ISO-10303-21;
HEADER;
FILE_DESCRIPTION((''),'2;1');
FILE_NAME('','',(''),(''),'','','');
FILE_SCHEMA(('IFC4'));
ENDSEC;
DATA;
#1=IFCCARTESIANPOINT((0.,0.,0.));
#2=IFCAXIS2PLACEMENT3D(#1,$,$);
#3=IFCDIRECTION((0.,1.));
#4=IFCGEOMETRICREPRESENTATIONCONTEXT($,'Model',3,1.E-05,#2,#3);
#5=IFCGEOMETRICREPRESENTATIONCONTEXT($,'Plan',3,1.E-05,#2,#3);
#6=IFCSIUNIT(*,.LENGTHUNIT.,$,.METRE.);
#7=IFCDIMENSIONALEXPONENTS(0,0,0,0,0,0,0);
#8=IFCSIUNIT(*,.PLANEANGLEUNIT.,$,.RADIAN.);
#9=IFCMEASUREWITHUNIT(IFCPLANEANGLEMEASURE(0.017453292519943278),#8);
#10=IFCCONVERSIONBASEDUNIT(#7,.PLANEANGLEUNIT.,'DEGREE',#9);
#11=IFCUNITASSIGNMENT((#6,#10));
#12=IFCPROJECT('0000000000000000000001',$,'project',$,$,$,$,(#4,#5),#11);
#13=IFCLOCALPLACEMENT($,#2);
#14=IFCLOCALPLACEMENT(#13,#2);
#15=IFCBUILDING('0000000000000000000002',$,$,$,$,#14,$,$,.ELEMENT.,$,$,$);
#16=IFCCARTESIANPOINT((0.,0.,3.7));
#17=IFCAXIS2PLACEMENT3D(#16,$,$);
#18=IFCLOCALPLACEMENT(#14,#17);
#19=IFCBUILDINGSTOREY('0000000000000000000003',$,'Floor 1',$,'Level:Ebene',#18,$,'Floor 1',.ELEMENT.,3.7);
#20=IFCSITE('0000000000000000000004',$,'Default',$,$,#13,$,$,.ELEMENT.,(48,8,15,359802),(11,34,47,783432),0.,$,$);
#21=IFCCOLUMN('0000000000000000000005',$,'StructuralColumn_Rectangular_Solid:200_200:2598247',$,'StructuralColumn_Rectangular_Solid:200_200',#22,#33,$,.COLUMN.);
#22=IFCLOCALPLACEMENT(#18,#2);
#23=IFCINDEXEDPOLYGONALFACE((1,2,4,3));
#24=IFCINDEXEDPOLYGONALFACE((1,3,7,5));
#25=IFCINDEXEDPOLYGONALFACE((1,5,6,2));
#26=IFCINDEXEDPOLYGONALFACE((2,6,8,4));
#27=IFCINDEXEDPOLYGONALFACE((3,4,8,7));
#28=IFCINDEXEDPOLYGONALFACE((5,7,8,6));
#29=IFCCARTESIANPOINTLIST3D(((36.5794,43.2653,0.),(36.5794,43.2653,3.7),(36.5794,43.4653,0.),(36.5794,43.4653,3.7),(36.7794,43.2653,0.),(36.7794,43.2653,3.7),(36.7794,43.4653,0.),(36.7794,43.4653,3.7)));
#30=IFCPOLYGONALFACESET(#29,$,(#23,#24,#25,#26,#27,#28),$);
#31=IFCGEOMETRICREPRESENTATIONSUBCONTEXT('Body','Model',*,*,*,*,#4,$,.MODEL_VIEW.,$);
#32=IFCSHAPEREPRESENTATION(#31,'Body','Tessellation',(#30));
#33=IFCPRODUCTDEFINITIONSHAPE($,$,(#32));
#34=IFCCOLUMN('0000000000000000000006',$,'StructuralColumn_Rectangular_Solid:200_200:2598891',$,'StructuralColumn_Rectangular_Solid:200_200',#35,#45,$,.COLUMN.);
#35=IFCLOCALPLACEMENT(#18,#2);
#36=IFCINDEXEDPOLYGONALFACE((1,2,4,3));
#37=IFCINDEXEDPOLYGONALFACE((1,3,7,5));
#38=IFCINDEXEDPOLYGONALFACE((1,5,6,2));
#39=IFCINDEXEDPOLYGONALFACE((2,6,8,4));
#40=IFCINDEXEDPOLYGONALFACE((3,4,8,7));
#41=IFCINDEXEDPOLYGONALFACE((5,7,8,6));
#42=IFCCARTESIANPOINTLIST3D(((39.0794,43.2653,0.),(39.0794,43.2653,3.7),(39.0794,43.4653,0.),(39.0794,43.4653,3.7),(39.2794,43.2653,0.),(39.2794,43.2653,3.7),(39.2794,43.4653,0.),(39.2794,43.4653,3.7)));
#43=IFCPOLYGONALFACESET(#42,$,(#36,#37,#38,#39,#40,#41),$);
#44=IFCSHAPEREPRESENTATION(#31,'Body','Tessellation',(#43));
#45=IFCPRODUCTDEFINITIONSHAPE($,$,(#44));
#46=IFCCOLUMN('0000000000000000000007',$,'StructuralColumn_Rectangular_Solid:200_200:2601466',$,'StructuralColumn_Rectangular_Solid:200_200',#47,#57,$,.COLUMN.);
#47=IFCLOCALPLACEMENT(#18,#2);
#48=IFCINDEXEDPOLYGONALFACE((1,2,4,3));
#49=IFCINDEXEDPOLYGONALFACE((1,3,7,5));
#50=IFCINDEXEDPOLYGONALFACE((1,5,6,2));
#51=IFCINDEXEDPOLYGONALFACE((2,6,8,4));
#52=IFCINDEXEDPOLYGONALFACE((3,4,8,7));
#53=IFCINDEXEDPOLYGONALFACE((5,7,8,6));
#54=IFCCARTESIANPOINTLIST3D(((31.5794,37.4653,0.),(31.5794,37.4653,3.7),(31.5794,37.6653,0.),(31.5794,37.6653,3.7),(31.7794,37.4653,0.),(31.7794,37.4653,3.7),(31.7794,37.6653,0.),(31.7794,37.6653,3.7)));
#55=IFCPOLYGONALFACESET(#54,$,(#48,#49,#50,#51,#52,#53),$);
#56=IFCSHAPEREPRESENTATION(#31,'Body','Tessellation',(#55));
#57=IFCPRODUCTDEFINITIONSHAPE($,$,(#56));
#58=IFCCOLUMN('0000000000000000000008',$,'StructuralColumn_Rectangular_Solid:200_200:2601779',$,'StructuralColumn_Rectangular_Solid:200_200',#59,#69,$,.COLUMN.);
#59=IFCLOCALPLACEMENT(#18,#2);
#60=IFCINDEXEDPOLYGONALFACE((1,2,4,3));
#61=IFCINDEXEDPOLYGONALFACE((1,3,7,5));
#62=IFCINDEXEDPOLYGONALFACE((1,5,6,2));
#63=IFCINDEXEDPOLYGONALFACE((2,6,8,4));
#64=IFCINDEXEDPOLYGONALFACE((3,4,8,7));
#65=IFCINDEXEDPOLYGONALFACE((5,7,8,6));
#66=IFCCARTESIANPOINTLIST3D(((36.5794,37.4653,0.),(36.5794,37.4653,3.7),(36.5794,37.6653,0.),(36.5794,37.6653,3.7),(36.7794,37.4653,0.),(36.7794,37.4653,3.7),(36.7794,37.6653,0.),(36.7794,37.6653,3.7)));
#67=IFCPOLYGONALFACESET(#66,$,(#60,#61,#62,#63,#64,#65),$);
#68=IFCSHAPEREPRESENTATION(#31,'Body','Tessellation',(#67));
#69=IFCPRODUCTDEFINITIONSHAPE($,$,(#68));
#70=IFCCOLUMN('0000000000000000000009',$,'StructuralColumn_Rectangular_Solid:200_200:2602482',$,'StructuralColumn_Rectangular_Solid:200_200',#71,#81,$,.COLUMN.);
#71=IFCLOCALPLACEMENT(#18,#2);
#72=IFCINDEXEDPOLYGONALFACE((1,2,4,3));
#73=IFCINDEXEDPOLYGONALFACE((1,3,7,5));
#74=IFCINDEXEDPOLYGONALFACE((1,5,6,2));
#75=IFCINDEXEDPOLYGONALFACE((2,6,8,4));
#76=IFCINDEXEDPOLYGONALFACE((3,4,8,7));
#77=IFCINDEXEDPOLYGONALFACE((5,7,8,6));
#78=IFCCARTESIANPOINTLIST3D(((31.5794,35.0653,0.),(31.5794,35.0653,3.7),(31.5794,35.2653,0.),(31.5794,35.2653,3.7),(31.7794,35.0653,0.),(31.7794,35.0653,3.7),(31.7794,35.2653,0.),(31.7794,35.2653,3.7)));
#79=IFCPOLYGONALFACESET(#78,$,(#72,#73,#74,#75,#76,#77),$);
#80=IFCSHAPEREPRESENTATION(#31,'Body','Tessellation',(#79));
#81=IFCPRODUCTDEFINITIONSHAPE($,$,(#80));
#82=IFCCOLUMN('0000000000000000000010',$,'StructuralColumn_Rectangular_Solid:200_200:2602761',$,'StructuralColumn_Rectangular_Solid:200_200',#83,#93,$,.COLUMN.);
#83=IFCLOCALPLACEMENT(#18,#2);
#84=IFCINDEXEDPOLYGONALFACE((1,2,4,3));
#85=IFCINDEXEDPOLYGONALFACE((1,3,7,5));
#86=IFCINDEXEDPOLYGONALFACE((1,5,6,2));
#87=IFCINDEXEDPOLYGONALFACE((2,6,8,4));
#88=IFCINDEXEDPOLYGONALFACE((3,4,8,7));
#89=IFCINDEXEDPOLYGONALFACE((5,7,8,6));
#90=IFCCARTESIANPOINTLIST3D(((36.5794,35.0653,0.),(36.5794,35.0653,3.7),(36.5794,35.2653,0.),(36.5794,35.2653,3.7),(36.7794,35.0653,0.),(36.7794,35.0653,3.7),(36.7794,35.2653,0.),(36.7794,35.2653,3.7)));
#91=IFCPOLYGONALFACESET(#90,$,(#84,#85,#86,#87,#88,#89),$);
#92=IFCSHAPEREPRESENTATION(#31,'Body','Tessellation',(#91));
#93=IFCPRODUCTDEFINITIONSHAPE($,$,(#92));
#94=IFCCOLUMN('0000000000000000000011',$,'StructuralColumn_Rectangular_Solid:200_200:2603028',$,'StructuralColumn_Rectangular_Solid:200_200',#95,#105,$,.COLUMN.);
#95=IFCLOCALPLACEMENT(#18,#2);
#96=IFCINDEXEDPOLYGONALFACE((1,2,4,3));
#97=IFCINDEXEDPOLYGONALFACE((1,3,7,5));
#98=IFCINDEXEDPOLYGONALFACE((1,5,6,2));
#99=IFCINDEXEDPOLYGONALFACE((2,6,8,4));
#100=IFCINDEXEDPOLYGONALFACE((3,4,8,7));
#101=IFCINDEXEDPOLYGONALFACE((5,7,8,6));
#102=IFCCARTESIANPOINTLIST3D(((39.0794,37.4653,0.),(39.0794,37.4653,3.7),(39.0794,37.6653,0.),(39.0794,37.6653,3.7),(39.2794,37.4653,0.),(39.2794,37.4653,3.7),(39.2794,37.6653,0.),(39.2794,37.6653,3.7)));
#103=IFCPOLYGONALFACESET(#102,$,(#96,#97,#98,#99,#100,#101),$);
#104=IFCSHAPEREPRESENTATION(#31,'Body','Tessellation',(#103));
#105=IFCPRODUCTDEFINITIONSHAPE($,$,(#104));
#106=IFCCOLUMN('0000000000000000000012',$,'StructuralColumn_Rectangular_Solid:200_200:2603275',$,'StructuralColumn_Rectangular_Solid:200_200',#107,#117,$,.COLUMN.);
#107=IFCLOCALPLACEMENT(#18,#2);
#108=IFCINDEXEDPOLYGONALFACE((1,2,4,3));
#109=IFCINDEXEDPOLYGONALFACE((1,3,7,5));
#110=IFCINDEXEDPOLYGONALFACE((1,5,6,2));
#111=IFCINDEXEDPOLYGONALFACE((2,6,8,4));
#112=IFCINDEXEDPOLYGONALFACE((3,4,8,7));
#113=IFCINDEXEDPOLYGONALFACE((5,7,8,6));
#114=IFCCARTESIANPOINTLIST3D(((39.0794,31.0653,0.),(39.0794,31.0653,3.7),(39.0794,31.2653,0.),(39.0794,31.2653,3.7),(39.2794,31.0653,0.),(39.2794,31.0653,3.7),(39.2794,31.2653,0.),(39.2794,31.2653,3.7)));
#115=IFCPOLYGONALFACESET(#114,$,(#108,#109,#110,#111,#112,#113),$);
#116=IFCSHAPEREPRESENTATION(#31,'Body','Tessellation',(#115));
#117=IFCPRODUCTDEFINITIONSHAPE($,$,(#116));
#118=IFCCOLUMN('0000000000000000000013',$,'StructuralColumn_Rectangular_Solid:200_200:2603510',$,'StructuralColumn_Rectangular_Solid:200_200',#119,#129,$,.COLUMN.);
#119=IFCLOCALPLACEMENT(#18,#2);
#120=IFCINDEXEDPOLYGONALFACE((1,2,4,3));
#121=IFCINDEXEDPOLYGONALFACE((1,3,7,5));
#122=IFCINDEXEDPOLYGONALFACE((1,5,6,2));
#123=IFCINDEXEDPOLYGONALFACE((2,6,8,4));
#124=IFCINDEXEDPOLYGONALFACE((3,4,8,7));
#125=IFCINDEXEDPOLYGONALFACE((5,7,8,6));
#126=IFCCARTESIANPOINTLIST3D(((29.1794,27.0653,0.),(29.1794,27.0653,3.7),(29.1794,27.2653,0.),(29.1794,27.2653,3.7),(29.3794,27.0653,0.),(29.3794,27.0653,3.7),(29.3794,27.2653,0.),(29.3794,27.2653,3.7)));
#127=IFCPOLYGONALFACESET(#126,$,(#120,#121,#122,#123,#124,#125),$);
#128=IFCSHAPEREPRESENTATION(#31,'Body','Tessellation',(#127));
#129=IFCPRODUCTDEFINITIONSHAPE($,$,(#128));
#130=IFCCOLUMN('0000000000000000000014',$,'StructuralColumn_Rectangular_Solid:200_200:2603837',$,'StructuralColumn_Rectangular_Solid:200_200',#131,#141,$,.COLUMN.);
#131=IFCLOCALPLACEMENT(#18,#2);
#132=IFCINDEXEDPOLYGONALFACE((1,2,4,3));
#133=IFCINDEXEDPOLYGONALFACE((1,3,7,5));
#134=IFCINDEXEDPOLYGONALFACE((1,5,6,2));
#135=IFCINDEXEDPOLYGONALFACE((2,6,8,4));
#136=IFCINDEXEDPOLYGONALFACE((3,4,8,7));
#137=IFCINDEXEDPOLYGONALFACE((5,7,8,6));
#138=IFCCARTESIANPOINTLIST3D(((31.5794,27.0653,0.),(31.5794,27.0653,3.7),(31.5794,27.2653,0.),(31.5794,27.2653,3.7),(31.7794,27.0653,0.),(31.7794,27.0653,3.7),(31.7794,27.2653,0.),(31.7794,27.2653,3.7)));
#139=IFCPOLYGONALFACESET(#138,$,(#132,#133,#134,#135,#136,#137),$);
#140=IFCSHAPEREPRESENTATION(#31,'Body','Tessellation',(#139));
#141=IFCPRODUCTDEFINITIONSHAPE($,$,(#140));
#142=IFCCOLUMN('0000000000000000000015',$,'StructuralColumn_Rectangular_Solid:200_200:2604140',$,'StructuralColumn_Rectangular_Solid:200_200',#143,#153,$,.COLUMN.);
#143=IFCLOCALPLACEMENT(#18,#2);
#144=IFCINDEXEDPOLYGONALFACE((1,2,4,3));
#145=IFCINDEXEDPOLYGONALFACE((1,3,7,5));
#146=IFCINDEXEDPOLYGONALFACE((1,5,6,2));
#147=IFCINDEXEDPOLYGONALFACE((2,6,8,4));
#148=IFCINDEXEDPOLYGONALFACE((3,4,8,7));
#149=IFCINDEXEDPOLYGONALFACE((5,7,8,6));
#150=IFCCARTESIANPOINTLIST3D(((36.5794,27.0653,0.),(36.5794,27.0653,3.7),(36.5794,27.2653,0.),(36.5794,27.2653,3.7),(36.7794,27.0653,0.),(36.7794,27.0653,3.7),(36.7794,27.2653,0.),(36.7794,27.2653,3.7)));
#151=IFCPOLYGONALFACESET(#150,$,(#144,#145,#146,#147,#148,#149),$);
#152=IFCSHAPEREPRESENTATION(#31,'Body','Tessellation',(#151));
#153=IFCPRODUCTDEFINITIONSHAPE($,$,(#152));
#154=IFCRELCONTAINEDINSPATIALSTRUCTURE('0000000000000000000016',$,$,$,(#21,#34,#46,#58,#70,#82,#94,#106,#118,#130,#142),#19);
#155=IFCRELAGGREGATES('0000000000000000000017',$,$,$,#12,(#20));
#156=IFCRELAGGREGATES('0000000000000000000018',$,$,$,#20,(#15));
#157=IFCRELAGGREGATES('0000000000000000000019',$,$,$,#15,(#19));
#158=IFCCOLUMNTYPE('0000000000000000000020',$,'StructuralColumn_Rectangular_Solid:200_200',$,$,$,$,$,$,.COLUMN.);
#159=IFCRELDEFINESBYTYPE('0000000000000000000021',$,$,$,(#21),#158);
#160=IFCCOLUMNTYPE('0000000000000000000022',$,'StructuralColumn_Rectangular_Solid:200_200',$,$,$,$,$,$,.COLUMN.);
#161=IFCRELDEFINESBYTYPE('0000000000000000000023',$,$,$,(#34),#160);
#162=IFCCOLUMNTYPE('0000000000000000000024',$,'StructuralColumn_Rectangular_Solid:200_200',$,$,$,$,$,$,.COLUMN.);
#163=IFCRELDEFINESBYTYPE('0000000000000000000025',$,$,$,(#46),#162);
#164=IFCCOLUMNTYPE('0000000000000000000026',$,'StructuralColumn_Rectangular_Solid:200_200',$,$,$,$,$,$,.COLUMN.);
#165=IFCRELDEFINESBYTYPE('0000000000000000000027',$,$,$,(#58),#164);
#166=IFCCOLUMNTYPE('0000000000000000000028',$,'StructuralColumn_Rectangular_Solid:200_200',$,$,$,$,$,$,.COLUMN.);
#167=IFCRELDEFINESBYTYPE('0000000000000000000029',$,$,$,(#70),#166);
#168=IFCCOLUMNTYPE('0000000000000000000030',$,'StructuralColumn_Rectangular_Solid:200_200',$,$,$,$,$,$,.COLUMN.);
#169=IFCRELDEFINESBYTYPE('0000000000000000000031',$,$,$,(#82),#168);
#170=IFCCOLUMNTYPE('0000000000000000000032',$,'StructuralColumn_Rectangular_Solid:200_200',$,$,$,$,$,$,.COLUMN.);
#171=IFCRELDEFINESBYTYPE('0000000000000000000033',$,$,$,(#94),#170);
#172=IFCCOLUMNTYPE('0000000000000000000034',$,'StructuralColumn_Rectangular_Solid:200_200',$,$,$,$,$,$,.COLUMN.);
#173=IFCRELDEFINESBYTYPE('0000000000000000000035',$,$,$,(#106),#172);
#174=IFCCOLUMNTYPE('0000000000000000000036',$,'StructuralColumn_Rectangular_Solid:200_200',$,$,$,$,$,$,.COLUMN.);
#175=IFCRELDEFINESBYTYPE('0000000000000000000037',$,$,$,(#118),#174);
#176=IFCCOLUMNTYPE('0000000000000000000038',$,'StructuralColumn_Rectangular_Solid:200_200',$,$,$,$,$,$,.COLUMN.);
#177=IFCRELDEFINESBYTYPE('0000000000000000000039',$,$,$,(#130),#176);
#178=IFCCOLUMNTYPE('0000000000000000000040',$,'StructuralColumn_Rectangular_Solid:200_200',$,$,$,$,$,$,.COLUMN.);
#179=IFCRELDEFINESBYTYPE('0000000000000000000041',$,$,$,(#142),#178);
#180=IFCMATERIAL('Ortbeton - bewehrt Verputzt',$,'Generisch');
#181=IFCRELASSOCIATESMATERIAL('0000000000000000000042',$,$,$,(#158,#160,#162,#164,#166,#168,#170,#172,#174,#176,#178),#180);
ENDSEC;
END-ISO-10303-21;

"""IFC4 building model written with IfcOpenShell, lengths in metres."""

from ifc_helpers import new_model, entity, si_unit, converted_unit, direction, frame, frame_2d, origin, origin_2d_with_axis, place, context, subcontext, project, spatial, rectangle, extrude, source, transform, mapped, material, material_profile, profile_set, type_object, type_shapes, element, save


model = new_model("IFC4")

# Units and contexts
model_context = context("Model", 3, precision=1e-05, world=origin(), true_north=direction((0.0, 1.0)))
plan_context = context("Plan", 3, precision=1e-05, world=origin(), true_north=direction((0.0, 1.0)))
body_context = subcontext(model_context, "Body", "Model", "MODEL_VIEW")
ifc_project = project(units=[si_unit("LENGTHUNIT", "METRE"), converted_unit("PLANEANGLEUNIT", "DEGREE", entity("IfcPlaneAngleMeasure", 0.017453292519943278), si_unit("PLANEANGLEUNIT", "RADIAN"), dimensions=[0, 0, 0, 0, 0, 0, 0])], contexts=[model_context, plan_context])

# Site, building, storey
site_placement = place(None, origin())
site = spatial("IfcSite", under=ifc_project, at=site_placement, Name="Default", CompositionType="ELEMENT", RefLatitude=(48, 8, 15, 359802), RefLongitude=(11, 34, 47, 783432), RefElevation=0.0)
building_placement = place(site_placement, origin())
building = spatial("IfcBuilding", under=site, at=building_placement, CompositionType="ELEMENT")
storey_placement = place(building_placement, frame((0.0, 0.0, 3.7)))
storey = spatial("IfcBuildingStorey", under=building, at=storey_placement, Name="Floor 1", ObjectType="Level:Ebene", LongName="Floor 1", CompositionType="ELEMENT", Elevation=3.7)

# Columns
ifc_material_1 = material(Name="Ortbeton - bewehrt Verputzt", Category="Generisch")
ifc_material_profile = material_profile(ifc_material_1, rectangle(XDim=0.2, YDim=0.2, at=frame_2d((0.0, 0.0), x_axis=(1.0, 0.0))), Name="200_200")
ifc_profile_set = profile_set([ifc_material_profile], Name="200_200")
column_type_1 = type_object("IfcColumnType", Name="StructuralColumn_Rectangular_Solid:200_200", PredefinedType="COLUMN", material=ifc_profile_set)
shared_shape_1 = source(origin(), body_context, "Body", "SweptSolid", [
    extrude(rectangle(XDim=0.2, YDim=0.2, at=frame_2d((0.0, 0.0), x_axis=(1.0, 0.0))), frame((36.6794, 43.3653, 3.7), z_axis=(0.0, 0.0, 1.0), x_axis=(-1.0, 0.0, 0.0)), (0.0, 0.0, 1.0), 3.7),
])
type_shapes(column_type_1, [shared_shape_1])
column_1_placement = place(storey_placement, frame((0.0, 0.0, -3.7)))
element("IfcColumn", 1, at=column_1_placement, inside=storey, type_object=column_type_1, Name="StructuralColumn_Rectangular_Solid:200_200:2598247", ObjectType="StructuralColumn_Rectangular_Solid:200_200", PredefinedType="COLUMN", context=body_context, shape_type="MappedRepresentation", body=[
    mapped(shared_shape_1, transform((0.0, 0.0, 0.0), scale=1.0)),
])
column_type_2 = type_object("IfcColumnType", Name="StructuralColumn_Rectangular_Solid:200_200", PredefinedType="COLUMN", material=ifc_profile_set)
shared_shape_2 = source(origin(), body_context, "Body", "SweptSolid", [
    extrude(rectangle(XDim=0.2, YDim=0.2, at=frame_2d((0.0, 0.0), x_axis=(1.0, 0.0))), frame((39.1794, 43.3653, 3.7), z_axis=(0.0, 0.0, 1.0), x_axis=(-1.0, 0.0, 0.0)), (0.0, 0.0, 1.0), 3.7),
])
type_shapes(column_type_2, [shared_shape_2])
column_2_placement = place(storey_placement, frame((0.0, 0.0, -3.7)))
element("IfcColumn", 2, at=column_2_placement, inside=storey, type_object=column_type_2, Name="StructuralColumn_Rectangular_Solid:200_200:2598891", ObjectType="StructuralColumn_Rectangular_Solid:200_200", PredefinedType="COLUMN", context=body_context, shape_type="MappedRepresentation", body=[
    mapped(shared_shape_2, transform((0.0, 0.0, 0.0), scale=1.0)),
])
column_type_3 = type_object("IfcColumnType", Name="StructuralColumn_Rectangular_Solid:200_200", PredefinedType="COLUMN", material=ifc_profile_set)
shared_shape_3 = source(origin(), body_context, "Body", "SweptSolid", [
    extrude(rectangle(XDim=0.2, YDim=0.2, at=frame_2d((0.0, 0.0), x_axis=(1.0, 0.0))), frame((31.6794, 37.5653, 3.7), z_axis=(0.0, 0.0, 1.0), x_axis=(-1.0, 0.0, 0.0)), (0.0, 0.0, 1.0), 3.7),
])
type_shapes(column_type_3, [shared_shape_3])
column_3_placement = place(storey_placement, frame((0.0, 0.0, -3.7)))
element("IfcColumn", 3, at=column_3_placement, inside=storey, type_object=column_type_3, Name="StructuralColumn_Rectangular_Solid:200_200:2601466", ObjectType="StructuralColumn_Rectangular_Solid:200_200", PredefinedType="COLUMN", context=body_context, shape_type="MappedRepresentation", body=[
    mapped(shared_shape_3, transform((0.0, 0.0, 0.0), scale=1.0)),
])
column_type_4 = type_object("IfcColumnType", Name="StructuralColumn_Rectangular_Solid:200_200", PredefinedType="COLUMN", material=ifc_profile_set)
shared_shape_4 = source(origin(), body_context, "Body", "SweptSolid", [
    extrude(rectangle(XDim=0.2, YDim=0.2, at=origin_2d_with_axis()), frame((36.6794, 37.5653, 3.7), z_axis=(0.0, 0.0, 1.0), x_axis=(-1.0, 0.0, 0.0)), (0.0, 0.0, 1.0), 3.7),
])
type_shapes(column_type_4, [shared_shape_4])
column_4_placement = place(storey_placement, frame((0.0, 0.0, -3.7)))
element("IfcColumn", 4, at=column_4_placement, inside=storey, type_object=column_type_4, Name="StructuralColumn_Rectangular_Solid:200_200:2601779", ObjectType="StructuralColumn_Rectangular_Solid:200_200", PredefinedType="COLUMN", context=body_context, shape_type="MappedRepresentation", body=[
    mapped(shared_shape_4, transform((0.0, 0.0, 0.0), scale=1.0)),
])
column_type_5 = type_object("IfcColumnType", Name="StructuralColumn_Rectangular_Solid:200_200", PredefinedType="COLUMN", material=ifc_profile_set)
shared_shape_5 = source(origin(), body_context, "Body", "SweptSolid", [
    extrude(rectangle(XDim=0.2, YDim=0.2, at=origin_2d_with_axis()), frame((31.6794, 35.1653, 3.7), z_axis=(0.0, 0.0, 1.0), x_axis=(-1.0, 0.0, 0.0)), (0.0, 0.0, 1.0), 3.7),
])
type_shapes(column_type_5, [shared_shape_5])
column_5_placement = place(storey_placement, frame((0.0, 0.0, -3.7)))
element("IfcColumn", 5, at=column_5_placement, inside=storey, type_object=column_type_5, Name="StructuralColumn_Rectangular_Solid:200_200:2602482", ObjectType="StructuralColumn_Rectangular_Solid:200_200", PredefinedType="COLUMN", context=body_context, shape_type="MappedRepresentation", body=[
    mapped(shared_shape_5, transform((0.0, 0.0, 0.0), scale=1.0)),
])
column_type_6 = type_object("IfcColumnType", Name="StructuralColumn_Rectangular_Solid:200_200", PredefinedType="COLUMN", material=ifc_profile_set)
shared_shape_6 = source(origin(), body_context, "Body", "SweptSolid", [
    extrude(rectangle(XDim=0.2, YDim=0.2, at=origin_2d_with_axis()), frame((36.6794, 35.1653, 3.7), z_axis=(0.0, 0.0, 1.0), x_axis=(-1.0, 0.0, 0.0)), (0.0, 0.0, 1.0), 3.7),
])
type_shapes(column_type_6, [shared_shape_6])
column_6_placement = place(storey_placement, frame((0.0, 0.0, -3.7)))
element("IfcColumn", 6, at=column_6_placement, inside=storey, type_object=column_type_6, Name="StructuralColumn_Rectangular_Solid:200_200:2602761", ObjectType="StructuralColumn_Rectangular_Solid:200_200", PredefinedType="COLUMN", context=body_context, shape_type="MappedRepresentation", body=[
    mapped(shared_shape_6, transform((0.0, 0.0, 0.0), scale=1.0)),
])
column_type_7 = type_object("IfcColumnType", Name="StructuralColumn_Rectangular_Solid:200_200", PredefinedType="COLUMN", material=ifc_profile_set)
shared_shape_7 = source(origin(), body_context, "Body", "SweptSolid", [
    extrude(rectangle(XDim=0.2, YDim=0.2, at=frame_2d((0.0, 0.0), x_axis=(1.0, 0.0))), frame((39.1794, 37.5653, 3.7), z_axis=(0.0, 0.0, 1.0), x_axis=(-1.0, 0.0, 0.0)), (0.0, 0.0, 1.0), 3.7),
])
type_shapes(column_type_7, [shared_shape_7])
column_7_placement = place(storey_placement, frame((0.0, 0.0, -3.7)))
element("IfcColumn", 7, at=column_7_placement, inside=storey, type_object=column_type_7, Name="StructuralColumn_Rectangular_Solid:200_200:2603028", ObjectType="StructuralColumn_Rectangular_Solid:200_200", PredefinedType="COLUMN", context=body_context, shape_type="MappedRepresentation", body=[
    mapped(shared_shape_7, transform((0.0, 0.0, 0.0), scale=1.0)),
])
column_type_8 = type_object("IfcColumnType", Name="StructuralColumn_Rectangular_Solid:200_200", PredefinedType="COLUMN", material=ifc_profile_set)
shared_shape_8 = source(origin(), body_context, "Body", "SweptSolid", [
    extrude(rectangle(XDim=0.2, YDim=0.2, at=frame_2d((0.0, 0.0), x_axis=(1.0, 0.0))), frame((39.1794, 31.1653, 3.7), z_axis=(0.0, 0.0, 1.0), x_axis=(-1.0, 0.0, 0.0)), (0.0, 0.0, 1.0), 3.7),
])
type_shapes(column_type_8, [shared_shape_8])
column_8_placement = place(storey_placement, frame((0.0, 0.0, -3.7)))
element("IfcColumn", 8, at=column_8_placement, inside=storey, type_object=column_type_8, Name="StructuralColumn_Rectangular_Solid:200_200:2603275", ObjectType="StructuralColumn_Rectangular_Solid:200_200", PredefinedType="COLUMN", context=body_context, shape_type="MappedRepresentation", body=[
    mapped(shared_shape_8, transform((0.0, 0.0, 0.0), scale=1.0)),
])
column_type_9 = type_object("IfcColumnType", Name="StructuralColumn_Rectangular_Solid:200_200", PredefinedType="COLUMN", material=ifc_profile_set)
shared_shape_9 = source(origin(), body_context, "Body", "SweptSolid", [
    extrude(rectangle(XDim=0.2, YDim=0.2, at=frame_2d((0.0, 0.0), x_axis=(1.0, 0.0))), frame((29.2794, 27.1653, 3.7), z_axis=(0.0, 0.0, 1.0), x_axis=(-1.0, 0.0, 0.0)), (0.0, 0.0, 1.0), 3.7),
])
type_shapes(column_type_9, [shared_shape_9])
column_9_placement = place(storey_placement, frame((0.0, 0.0, -3.7)))
element("IfcColumn", 9, at=column_9_placement, inside=storey, type_object=column_type_9, Name="StructuralColumn_Rectangular_Solid:200_200:2603510", ObjectType="StructuralColumn_Rectangular_Solid:200_200", PredefinedType="COLUMN", context=body_context, shape_type="MappedRepresentation", body=[
    mapped(shared_shape_9, transform((0.0, 0.0, 0.0), scale=1.0)),
])
column_type_10 = type_object("IfcColumnType", Name="StructuralColumn_Rectangular_Solid:200_200", PredefinedType="COLUMN", material=ifc_profile_set)
shared_shape_10 = source(origin(), body_context, "Body", "SweptSolid", [
    extrude(rectangle(XDim=0.2, YDim=0.2, at=frame_2d((0.0, 0.0), x_axis=(1.0, 0.0))), frame((31.6794, 27.1653, 3.7), z_axis=(0.0, 0.0, 1.0), x_axis=(-1.0, 0.0, 0.0)), (0.0, 0.0, 1.0), 3.7),
])
type_shapes(column_type_10, [shared_shape_10])
column_10_placement = place(storey_placement, frame((0.0, 0.0, -3.7)))
element("IfcColumn", 10, at=column_10_placement, inside=storey, type_object=column_type_10, Name="StructuralColumn_Rectangular_Solid:200_200:2603837", ObjectType="StructuralColumn_Rectangular_Solid:200_200", PredefinedType="COLUMN", context=body_context, shape_type="MappedRepresentation", body=[
    mapped(shared_shape_10, transform((0.0, 0.0, 0.0), scale=1.0)),
])
column_type_11 = type_object("IfcColumnType", Name="StructuralColumn_Rectangular_Solid:200_200", PredefinedType="COLUMN", material=ifc_profile_set)
shared_shape_11 = source(origin(), body_context, "Body", "SweptSolid", [
    extrude(rectangle(XDim=0.2, YDim=0.2, at=origin_2d_with_axis()), frame((36.6794, 27.1653, 3.7), z_axis=(0.0, 0.0, 1.0), x_axis=(-1.0, 0.0, 0.0)), (0.0, 0.0, 1.0), 3.7),
])
type_shapes(column_type_11, [shared_shape_11])
column_11_placement = place(storey_placement, frame((0.0, 0.0, -3.7)))
element("IfcColumn", 11, at=column_11_placement, inside=storey, type_object=column_type_11, Name="StructuralColumn_Rectangular_Solid:200_200:2604140", ObjectType="StructuralColumn_Rectangular_Solid:200_200", PredefinedType="COLUMN", context=body_context, shape_type="MappedRepresentation", body=[
    mapped(shared_shape_11, transform((0.0, 0.0, 0.0), scale=1.0)),
])

save(model, "model.ifc")
